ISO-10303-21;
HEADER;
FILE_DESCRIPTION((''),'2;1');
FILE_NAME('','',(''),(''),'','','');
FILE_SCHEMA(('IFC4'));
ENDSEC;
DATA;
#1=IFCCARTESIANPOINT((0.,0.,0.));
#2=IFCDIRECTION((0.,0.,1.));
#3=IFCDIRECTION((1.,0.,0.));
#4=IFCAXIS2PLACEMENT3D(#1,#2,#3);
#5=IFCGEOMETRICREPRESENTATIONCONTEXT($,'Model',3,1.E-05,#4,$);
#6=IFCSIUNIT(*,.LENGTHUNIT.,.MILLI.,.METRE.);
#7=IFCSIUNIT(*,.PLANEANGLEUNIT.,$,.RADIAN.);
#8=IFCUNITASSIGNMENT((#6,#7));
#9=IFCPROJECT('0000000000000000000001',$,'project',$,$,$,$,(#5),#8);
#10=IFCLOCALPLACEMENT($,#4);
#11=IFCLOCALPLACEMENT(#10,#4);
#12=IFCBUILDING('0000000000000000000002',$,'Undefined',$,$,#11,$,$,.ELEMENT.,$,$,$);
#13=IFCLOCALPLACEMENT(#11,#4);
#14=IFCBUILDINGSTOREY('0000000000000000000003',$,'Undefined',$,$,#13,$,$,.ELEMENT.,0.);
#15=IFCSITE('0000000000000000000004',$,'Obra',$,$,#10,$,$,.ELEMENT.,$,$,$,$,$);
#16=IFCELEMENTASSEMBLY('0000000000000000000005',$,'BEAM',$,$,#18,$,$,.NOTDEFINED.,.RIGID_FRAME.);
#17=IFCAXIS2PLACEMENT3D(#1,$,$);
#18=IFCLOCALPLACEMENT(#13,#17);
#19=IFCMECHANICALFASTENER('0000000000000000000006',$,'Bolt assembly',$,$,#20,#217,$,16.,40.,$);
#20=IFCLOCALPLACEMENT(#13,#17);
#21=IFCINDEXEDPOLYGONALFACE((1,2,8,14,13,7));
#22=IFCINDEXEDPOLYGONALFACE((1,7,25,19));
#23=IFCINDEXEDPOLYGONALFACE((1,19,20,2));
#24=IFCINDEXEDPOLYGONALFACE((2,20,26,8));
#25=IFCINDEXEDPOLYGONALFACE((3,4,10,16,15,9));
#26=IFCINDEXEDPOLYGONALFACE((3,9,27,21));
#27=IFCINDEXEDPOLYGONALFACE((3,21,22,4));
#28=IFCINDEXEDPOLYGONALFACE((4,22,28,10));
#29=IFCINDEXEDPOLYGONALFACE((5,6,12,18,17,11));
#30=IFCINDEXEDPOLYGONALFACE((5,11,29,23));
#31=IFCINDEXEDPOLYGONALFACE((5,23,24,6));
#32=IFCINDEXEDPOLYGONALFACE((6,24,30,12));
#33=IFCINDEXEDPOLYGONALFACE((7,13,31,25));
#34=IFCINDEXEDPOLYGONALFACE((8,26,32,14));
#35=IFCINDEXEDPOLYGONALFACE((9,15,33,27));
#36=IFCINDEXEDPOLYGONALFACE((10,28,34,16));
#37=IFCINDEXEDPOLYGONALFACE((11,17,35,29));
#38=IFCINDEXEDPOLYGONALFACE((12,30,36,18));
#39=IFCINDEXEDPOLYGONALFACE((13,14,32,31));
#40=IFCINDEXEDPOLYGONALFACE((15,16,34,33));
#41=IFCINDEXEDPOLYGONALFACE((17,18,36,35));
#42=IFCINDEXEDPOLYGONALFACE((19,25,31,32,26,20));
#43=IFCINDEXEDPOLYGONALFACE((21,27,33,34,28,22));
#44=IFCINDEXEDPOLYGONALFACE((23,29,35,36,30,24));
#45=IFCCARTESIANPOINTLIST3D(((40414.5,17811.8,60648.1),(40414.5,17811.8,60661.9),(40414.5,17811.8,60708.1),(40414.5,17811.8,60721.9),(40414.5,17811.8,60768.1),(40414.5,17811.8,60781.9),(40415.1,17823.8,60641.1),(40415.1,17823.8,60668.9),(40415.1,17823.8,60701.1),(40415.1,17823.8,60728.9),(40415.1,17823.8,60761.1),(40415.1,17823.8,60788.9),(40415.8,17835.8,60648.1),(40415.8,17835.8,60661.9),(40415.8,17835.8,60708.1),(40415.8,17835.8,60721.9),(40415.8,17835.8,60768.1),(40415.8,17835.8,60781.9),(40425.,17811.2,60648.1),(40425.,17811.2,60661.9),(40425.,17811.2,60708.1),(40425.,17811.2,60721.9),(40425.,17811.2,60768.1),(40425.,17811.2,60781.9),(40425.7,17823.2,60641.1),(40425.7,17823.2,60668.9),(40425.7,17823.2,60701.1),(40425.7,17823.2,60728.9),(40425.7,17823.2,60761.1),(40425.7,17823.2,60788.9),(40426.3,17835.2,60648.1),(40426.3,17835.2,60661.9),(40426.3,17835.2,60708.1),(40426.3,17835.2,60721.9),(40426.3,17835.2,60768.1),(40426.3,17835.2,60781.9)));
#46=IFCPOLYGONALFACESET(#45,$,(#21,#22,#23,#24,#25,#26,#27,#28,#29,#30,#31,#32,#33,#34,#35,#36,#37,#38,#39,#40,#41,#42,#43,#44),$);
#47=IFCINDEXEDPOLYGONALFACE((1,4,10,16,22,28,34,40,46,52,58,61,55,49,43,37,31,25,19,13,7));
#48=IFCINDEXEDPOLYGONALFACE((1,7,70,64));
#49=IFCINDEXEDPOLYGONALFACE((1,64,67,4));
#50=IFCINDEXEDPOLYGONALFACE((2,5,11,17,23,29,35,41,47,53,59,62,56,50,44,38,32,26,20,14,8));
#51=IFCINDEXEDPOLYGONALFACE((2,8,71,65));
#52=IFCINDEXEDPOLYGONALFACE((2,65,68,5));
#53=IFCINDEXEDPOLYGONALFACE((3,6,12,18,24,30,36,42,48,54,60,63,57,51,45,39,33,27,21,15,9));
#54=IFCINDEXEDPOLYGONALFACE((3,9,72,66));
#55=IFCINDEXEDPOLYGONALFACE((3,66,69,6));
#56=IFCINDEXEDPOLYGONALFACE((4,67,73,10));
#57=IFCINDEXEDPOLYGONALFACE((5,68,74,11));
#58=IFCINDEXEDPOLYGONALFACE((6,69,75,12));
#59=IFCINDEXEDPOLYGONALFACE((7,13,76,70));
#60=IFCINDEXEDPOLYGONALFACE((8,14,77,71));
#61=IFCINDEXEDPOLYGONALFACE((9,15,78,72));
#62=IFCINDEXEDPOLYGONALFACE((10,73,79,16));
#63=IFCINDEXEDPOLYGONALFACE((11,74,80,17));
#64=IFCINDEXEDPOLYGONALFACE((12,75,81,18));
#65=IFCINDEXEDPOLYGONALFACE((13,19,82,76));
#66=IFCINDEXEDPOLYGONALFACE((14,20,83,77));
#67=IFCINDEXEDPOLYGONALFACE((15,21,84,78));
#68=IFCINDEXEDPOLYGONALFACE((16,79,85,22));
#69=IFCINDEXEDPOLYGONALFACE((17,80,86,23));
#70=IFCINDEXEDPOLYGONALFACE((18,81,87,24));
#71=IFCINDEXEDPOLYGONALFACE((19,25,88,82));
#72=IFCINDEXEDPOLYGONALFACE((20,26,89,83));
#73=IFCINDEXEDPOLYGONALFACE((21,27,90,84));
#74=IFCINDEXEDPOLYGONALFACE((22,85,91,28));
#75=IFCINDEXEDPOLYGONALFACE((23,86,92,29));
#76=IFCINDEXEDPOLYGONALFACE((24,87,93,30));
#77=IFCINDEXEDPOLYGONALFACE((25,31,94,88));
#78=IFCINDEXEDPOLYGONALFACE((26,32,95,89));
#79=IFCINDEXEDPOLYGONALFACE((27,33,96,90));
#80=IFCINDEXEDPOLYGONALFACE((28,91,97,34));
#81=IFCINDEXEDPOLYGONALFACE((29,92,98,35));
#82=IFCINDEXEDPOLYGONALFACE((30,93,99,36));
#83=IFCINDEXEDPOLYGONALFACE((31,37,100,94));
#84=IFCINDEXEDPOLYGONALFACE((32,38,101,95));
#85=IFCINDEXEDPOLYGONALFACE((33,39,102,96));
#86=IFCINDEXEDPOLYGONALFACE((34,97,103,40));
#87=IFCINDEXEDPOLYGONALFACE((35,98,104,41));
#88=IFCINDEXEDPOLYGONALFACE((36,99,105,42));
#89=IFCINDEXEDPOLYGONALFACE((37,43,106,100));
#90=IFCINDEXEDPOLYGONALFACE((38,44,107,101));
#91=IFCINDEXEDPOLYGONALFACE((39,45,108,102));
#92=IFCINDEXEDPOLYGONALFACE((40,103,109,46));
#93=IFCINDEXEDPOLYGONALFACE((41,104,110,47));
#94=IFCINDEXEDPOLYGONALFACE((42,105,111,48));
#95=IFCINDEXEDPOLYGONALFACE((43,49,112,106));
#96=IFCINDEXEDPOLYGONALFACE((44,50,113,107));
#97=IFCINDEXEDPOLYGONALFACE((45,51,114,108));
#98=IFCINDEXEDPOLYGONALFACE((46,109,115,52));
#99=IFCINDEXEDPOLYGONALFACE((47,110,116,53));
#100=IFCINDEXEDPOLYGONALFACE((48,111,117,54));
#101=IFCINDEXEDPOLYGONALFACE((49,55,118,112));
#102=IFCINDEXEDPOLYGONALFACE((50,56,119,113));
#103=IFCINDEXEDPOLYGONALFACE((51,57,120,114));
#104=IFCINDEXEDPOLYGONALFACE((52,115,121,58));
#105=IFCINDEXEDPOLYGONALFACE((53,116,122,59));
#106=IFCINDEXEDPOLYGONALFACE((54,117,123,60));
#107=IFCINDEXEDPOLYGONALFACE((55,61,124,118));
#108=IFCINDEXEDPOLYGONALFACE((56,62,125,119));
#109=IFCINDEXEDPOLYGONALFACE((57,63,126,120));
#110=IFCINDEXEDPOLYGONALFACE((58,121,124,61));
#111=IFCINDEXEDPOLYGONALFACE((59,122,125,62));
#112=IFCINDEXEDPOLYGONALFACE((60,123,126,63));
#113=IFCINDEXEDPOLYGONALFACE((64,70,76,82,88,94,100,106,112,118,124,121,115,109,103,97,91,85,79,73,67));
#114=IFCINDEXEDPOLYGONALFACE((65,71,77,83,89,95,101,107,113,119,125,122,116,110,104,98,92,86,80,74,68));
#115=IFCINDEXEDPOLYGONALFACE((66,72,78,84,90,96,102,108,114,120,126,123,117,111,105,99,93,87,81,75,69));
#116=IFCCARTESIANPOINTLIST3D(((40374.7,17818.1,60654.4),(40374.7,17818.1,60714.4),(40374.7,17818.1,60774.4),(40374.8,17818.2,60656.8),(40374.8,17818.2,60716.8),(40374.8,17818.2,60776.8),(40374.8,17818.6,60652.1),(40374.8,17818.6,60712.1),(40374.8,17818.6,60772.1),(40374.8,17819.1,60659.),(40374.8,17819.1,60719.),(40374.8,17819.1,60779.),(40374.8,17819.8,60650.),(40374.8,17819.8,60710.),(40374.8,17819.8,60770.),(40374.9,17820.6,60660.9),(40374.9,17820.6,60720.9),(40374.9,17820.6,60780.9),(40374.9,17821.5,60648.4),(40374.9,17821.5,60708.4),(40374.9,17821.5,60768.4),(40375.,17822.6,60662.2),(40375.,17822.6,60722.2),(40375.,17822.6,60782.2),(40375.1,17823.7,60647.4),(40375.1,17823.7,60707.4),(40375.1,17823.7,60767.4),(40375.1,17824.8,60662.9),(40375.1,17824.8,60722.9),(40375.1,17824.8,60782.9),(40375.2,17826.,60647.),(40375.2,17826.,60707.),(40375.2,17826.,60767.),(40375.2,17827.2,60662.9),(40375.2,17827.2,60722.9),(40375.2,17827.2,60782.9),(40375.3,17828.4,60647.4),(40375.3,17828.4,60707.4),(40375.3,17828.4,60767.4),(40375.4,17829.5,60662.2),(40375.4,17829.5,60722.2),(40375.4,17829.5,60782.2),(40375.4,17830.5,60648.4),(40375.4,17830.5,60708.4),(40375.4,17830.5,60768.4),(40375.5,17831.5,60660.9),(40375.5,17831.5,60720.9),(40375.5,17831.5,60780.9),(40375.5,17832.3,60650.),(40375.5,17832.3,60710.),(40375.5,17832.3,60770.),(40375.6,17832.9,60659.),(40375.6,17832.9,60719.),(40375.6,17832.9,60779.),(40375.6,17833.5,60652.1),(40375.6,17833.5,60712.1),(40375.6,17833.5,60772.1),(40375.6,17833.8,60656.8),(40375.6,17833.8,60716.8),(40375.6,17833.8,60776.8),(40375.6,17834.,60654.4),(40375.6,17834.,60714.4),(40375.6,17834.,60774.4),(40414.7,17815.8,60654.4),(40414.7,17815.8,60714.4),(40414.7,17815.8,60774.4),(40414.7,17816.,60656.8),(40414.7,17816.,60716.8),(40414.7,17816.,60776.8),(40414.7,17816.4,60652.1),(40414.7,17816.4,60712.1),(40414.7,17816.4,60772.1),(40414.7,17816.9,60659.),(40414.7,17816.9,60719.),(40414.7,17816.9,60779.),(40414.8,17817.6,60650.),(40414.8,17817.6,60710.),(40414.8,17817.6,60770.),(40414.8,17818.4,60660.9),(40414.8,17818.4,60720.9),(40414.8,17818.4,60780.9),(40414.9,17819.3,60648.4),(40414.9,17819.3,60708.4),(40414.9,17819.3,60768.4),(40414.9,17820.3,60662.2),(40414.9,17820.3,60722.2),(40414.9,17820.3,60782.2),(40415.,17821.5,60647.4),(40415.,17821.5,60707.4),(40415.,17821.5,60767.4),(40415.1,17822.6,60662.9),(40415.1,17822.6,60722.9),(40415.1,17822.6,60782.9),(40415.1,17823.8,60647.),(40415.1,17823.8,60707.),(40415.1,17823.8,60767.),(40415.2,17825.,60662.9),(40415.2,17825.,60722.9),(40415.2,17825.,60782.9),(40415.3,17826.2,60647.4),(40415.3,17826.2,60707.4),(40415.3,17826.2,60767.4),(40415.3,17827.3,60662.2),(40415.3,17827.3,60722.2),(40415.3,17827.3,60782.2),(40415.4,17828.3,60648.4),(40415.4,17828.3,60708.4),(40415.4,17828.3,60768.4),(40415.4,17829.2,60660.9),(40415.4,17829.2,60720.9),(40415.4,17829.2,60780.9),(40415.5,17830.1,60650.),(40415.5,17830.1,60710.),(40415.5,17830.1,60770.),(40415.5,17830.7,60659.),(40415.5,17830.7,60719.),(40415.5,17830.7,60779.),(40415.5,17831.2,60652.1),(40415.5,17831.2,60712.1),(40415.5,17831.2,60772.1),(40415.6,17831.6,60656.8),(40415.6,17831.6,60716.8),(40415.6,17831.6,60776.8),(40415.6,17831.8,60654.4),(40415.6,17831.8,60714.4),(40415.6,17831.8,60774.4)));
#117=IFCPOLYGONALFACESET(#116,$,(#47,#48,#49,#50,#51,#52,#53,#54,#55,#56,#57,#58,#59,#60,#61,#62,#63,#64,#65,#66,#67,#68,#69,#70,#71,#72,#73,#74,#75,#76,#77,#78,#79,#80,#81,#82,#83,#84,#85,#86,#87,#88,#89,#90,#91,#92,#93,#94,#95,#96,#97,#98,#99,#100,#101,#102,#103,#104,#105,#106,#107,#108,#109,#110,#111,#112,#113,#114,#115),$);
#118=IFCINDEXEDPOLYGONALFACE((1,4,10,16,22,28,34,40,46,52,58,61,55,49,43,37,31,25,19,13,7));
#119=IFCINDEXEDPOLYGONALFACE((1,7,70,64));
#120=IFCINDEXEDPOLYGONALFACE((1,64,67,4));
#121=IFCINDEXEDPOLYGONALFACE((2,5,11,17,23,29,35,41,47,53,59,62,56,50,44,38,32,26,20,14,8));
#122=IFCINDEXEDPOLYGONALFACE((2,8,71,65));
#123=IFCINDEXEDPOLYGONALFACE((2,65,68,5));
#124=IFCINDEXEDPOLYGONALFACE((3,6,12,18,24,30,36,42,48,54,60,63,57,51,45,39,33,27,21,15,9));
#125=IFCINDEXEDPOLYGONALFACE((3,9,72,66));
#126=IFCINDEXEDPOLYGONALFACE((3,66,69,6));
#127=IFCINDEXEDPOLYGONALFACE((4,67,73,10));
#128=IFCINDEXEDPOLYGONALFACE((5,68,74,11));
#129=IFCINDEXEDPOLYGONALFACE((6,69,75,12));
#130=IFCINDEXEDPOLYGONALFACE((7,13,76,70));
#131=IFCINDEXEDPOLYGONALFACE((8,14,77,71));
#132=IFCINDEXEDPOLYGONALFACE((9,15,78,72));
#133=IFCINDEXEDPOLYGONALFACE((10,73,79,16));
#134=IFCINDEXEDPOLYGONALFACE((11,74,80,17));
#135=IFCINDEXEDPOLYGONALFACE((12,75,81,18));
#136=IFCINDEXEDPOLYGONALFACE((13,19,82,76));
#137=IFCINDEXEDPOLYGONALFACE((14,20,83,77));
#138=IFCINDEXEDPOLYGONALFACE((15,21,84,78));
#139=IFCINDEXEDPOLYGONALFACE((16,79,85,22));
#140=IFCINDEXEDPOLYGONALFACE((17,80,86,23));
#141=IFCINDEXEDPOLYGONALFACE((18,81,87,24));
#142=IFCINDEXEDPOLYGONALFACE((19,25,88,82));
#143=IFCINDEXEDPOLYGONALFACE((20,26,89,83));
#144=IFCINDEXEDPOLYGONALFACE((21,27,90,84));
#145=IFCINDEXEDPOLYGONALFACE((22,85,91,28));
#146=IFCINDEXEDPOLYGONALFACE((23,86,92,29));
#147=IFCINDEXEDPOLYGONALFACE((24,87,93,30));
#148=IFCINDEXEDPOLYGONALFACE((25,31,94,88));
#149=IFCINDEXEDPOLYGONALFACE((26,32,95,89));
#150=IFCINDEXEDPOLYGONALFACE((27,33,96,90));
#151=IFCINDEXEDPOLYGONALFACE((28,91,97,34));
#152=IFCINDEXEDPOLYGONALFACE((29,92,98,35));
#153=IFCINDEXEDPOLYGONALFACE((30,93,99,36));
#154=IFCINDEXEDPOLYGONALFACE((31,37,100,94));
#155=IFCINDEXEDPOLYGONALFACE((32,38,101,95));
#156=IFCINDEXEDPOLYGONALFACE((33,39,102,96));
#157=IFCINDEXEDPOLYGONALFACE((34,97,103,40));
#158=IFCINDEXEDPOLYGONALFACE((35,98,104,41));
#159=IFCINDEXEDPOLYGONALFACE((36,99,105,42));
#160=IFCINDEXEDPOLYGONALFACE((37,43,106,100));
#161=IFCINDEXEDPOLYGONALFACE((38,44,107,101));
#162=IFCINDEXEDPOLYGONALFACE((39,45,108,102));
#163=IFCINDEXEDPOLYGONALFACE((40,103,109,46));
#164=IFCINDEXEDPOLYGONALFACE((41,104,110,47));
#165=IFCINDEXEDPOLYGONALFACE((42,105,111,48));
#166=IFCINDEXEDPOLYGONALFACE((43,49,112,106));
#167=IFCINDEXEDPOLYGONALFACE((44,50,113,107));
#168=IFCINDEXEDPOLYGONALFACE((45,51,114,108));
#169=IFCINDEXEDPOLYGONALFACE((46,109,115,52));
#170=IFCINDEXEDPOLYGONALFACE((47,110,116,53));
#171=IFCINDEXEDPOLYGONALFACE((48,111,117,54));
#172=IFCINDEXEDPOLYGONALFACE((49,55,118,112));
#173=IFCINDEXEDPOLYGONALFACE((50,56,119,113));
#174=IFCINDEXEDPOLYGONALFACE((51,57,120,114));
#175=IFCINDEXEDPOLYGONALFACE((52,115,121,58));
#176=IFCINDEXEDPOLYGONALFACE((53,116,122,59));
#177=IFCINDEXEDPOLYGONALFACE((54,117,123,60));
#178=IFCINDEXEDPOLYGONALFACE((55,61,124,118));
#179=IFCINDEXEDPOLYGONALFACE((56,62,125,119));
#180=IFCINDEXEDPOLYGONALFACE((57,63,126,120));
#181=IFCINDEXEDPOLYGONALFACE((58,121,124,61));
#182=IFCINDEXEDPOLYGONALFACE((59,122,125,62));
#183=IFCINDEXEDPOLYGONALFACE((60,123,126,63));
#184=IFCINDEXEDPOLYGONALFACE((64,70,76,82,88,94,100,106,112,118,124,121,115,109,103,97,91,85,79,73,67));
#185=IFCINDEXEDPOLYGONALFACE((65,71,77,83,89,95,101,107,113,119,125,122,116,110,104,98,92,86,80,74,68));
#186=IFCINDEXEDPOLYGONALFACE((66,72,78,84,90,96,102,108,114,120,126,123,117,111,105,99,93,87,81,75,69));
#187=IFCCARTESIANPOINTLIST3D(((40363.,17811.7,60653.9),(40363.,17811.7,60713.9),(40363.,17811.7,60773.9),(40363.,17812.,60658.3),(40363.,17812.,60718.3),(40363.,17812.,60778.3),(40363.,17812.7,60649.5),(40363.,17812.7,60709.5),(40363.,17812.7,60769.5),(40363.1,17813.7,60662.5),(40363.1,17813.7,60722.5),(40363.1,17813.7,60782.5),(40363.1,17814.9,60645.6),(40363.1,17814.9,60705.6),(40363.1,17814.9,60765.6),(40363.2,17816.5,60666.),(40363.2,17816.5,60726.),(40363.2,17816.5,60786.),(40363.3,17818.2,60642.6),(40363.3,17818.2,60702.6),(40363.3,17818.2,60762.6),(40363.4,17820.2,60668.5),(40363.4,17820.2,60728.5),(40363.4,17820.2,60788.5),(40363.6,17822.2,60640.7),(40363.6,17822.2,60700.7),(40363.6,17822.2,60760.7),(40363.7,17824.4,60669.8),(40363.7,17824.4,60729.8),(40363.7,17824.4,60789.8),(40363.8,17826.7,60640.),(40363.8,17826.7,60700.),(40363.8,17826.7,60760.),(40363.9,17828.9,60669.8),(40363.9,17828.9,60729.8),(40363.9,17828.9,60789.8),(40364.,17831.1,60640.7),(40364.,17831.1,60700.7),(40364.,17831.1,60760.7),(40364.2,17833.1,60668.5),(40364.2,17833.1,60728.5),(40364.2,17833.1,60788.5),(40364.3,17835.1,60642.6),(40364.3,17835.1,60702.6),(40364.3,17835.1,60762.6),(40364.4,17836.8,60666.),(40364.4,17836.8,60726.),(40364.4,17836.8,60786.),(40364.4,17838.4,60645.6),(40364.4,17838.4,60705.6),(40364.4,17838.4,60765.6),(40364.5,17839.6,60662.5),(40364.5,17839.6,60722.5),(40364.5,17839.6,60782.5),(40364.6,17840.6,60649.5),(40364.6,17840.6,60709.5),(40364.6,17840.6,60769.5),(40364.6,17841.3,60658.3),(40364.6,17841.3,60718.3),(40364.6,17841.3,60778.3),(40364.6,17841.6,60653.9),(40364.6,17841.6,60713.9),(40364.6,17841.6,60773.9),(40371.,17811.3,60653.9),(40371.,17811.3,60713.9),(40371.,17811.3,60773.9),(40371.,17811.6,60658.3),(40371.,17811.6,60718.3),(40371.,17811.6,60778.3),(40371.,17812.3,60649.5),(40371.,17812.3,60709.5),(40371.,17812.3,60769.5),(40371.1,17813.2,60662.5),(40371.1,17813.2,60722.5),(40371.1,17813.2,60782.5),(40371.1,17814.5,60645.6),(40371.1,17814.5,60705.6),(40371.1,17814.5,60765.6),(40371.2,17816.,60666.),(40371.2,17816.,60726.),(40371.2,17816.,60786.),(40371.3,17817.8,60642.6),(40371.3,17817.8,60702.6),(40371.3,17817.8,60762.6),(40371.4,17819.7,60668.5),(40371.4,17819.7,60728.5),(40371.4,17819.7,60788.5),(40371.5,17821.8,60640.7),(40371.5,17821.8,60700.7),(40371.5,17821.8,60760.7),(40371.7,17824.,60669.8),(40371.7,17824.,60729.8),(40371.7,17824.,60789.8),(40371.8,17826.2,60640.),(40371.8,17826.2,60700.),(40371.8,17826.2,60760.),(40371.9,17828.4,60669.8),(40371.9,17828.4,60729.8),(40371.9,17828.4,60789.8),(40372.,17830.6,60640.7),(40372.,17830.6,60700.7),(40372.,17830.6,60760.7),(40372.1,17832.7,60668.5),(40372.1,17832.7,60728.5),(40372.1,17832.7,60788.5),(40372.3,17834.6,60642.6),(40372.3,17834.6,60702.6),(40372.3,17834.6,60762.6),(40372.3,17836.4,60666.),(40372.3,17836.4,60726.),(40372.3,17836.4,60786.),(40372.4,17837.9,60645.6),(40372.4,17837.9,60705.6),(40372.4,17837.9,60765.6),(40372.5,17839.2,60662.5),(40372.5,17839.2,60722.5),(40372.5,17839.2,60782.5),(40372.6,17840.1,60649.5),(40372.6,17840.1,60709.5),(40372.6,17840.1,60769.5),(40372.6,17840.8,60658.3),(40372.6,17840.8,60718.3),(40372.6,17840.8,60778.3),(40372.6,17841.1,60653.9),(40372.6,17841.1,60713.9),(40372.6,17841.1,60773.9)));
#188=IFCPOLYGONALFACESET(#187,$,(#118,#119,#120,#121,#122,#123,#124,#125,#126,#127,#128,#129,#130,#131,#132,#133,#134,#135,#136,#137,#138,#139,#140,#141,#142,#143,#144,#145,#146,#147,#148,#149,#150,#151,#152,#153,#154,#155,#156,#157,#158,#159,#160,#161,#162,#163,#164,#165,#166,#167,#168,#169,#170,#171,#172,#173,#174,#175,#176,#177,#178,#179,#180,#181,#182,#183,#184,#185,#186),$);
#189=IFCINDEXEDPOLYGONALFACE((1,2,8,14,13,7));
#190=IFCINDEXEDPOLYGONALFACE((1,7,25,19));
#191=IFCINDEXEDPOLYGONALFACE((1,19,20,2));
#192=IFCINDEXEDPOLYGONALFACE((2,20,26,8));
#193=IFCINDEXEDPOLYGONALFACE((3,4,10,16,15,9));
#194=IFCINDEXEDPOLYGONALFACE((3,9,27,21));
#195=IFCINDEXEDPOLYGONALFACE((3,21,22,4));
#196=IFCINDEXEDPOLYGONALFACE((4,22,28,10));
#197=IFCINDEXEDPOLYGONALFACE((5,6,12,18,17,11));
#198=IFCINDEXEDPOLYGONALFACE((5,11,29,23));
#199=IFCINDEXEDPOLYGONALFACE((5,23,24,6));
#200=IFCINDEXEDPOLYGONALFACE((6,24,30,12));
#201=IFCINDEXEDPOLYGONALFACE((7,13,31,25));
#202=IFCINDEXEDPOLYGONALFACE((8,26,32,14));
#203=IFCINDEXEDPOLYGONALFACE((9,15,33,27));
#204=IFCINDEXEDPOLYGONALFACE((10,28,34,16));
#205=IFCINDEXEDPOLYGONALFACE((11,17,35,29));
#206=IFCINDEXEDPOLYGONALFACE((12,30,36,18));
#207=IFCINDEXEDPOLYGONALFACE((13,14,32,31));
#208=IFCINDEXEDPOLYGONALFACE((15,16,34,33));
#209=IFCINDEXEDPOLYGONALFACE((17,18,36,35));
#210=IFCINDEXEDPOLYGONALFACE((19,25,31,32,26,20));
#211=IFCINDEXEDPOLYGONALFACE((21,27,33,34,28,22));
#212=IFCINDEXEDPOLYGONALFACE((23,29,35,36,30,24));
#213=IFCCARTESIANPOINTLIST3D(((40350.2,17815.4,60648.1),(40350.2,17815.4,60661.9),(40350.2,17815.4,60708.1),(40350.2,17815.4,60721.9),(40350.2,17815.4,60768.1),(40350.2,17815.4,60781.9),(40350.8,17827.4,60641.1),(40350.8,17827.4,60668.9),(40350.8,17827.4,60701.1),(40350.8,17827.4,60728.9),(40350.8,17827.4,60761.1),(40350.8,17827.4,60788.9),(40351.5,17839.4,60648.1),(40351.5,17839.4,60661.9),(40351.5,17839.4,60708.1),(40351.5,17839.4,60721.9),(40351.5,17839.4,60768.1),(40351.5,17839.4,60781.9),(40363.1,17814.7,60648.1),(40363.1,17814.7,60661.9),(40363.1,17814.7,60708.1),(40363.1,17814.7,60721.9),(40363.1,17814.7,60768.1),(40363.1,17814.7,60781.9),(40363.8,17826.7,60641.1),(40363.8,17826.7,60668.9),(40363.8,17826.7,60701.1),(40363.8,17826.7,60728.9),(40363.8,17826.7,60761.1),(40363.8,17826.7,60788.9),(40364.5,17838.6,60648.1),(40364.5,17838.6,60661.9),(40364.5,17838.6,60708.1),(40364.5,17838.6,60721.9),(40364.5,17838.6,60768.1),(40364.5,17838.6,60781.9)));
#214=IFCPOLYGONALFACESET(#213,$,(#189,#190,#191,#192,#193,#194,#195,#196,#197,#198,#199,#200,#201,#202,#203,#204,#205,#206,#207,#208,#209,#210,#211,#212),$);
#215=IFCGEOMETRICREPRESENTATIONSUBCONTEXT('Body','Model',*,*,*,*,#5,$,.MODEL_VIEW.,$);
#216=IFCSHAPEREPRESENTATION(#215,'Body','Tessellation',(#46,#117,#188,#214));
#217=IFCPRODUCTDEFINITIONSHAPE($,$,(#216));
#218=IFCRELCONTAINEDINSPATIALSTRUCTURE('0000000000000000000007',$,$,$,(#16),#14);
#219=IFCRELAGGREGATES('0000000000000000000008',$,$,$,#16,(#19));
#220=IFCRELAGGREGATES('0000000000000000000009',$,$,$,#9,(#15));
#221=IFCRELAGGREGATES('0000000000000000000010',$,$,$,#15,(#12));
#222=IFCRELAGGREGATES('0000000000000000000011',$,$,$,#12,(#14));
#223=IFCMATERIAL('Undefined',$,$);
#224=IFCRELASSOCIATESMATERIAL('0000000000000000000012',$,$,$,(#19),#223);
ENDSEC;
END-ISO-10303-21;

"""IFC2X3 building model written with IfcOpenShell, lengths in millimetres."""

from ifc_helpers import new_model, si_unit, frame, origin_with_axes, origin_2d_with_axis, place, context, subcontext, project, spatial, polyline, circle, outline, extrude, source, transform, mapped, material, element, aggregate, save


model = new_model("IFC2X3")

# Units and contexts
model_context = context("Model", 3, precision=1e-05, world=origin_with_axes())
body_context = subcontext(model_context, "Body", "Model", "MODEL_VIEW")
ifc_project = project(units=[si_unit("LENGTHUNIT", "METRE", prefix="MILLI"), si_unit("PLANEANGLEUNIT", "RADIAN")], contexts=[model_context])

# Site, building, storey
site_placement = place(None, origin_with_axes())
site = spatial("IfcSite", under=ifc_project, at=site_placement, Name="Obra", CompositionType="ELEMENT")
building_placement = place(site_placement, origin_with_axes())
building = spatial("IfcBuilding", under=site, at=building_placement, Name="Undefined", CompositionType="ELEMENT")
storey_placement = place(building_placement, origin_with_axes())
storey = spatial("IfcBuildingStorey", under=building, at=storey_placement, Name="Undefined", CompositionType="ELEMENT", Elevation=0.0)

# Element assembly, mechanical fastener
ifc_material_1 = material(Name="Undefined")
shared_shape_1 = source(origin_with_axes(), body_context, "Body", "SweptSolid", [
    extrude(outline(polyline([(13.9, 0.0), (6.9, 12.0), (-6.9, 12.0), (-13.9, 0.0), (-6.9, -12.0), (6.9, -12.0), (13.9, 0.0)])), frame((0.0, -19.7, 0.0), z_axis=(0.0, 1.0, 0.0), x_axis=(1.0, 0.0, 0.0)), (0.0, 0.0, 1.0), 10.6),
    extrude(circle(Radius=8.0, at=origin_2d_with_axis()), frame((0.0, -9.1, 0.0), z_axis=(0.0, 1.0, 0.0), x_axis=(1.0, 0.0, 0.0)), (0.0, 0.0, 1.0), 40.0),
    extrude(circle(Radius=15.0, at=origin_2d_with_axis()), frame((0.0, 34.3, 0.0), z_axis=(0.0, 1.0, 0.0), x_axis=(1.0, 0.0, 0.0)), (0.0, 0.0, 1.0), 8.0),
    extrude(outline(polyline([(13.9, 0.0), (6.9, 12.0), (-6.9, 12.0), (-13.9, 0.0), (-6.9, -12.0), (6.9, -12.0), (13.9, 0.0)])), frame((0.0, 42.3, 0.0), z_axis=(0.0, 1.0, 0.0), x_axis=(1.0, 0.0, 0.0)), (0.0, 0.0, 1.0), 13.0),
])
assembly_1_placement = place(storey_placement, origin_with_axes())
assembly_1 = element("IfcElementAssembly", 1, at=assembly_1_placement, inside=storey, Name="BEAM", AssemblyPlace="NOTDEFINED", PredefinedType="RIGID_FRAME")
mechanical_fastener_1_placement = place(assembly_1_placement, frame((40403.3, 17774.4, 60835.0), z_axis=(0.055268, 0.998472, 0.0), x_axis=(0.0, 0.0, -1.0)))
mechanical_fastener_1 = element("IfcMechanicalFastener", 2, at=mechanical_fastener_1_placement, material=ifc_material_1, Name="Bolt assembly", NominalDiameter=16.0, NominalLength=40.0, context=body_context, shape_type="MappedRepresentation", body=[
    mapped(shared_shape_1, transform((60.0, 0.0, 50.0))),
    mapped(shared_shape_1, transform((120.0, 0.0, 50.0))),
    mapped(shared_shape_1, transform((180.0, 0.0, 50.0))),
])

aggregate(assembly_1, [mechanical_fastener_1])

save(model, "model.ifc")
